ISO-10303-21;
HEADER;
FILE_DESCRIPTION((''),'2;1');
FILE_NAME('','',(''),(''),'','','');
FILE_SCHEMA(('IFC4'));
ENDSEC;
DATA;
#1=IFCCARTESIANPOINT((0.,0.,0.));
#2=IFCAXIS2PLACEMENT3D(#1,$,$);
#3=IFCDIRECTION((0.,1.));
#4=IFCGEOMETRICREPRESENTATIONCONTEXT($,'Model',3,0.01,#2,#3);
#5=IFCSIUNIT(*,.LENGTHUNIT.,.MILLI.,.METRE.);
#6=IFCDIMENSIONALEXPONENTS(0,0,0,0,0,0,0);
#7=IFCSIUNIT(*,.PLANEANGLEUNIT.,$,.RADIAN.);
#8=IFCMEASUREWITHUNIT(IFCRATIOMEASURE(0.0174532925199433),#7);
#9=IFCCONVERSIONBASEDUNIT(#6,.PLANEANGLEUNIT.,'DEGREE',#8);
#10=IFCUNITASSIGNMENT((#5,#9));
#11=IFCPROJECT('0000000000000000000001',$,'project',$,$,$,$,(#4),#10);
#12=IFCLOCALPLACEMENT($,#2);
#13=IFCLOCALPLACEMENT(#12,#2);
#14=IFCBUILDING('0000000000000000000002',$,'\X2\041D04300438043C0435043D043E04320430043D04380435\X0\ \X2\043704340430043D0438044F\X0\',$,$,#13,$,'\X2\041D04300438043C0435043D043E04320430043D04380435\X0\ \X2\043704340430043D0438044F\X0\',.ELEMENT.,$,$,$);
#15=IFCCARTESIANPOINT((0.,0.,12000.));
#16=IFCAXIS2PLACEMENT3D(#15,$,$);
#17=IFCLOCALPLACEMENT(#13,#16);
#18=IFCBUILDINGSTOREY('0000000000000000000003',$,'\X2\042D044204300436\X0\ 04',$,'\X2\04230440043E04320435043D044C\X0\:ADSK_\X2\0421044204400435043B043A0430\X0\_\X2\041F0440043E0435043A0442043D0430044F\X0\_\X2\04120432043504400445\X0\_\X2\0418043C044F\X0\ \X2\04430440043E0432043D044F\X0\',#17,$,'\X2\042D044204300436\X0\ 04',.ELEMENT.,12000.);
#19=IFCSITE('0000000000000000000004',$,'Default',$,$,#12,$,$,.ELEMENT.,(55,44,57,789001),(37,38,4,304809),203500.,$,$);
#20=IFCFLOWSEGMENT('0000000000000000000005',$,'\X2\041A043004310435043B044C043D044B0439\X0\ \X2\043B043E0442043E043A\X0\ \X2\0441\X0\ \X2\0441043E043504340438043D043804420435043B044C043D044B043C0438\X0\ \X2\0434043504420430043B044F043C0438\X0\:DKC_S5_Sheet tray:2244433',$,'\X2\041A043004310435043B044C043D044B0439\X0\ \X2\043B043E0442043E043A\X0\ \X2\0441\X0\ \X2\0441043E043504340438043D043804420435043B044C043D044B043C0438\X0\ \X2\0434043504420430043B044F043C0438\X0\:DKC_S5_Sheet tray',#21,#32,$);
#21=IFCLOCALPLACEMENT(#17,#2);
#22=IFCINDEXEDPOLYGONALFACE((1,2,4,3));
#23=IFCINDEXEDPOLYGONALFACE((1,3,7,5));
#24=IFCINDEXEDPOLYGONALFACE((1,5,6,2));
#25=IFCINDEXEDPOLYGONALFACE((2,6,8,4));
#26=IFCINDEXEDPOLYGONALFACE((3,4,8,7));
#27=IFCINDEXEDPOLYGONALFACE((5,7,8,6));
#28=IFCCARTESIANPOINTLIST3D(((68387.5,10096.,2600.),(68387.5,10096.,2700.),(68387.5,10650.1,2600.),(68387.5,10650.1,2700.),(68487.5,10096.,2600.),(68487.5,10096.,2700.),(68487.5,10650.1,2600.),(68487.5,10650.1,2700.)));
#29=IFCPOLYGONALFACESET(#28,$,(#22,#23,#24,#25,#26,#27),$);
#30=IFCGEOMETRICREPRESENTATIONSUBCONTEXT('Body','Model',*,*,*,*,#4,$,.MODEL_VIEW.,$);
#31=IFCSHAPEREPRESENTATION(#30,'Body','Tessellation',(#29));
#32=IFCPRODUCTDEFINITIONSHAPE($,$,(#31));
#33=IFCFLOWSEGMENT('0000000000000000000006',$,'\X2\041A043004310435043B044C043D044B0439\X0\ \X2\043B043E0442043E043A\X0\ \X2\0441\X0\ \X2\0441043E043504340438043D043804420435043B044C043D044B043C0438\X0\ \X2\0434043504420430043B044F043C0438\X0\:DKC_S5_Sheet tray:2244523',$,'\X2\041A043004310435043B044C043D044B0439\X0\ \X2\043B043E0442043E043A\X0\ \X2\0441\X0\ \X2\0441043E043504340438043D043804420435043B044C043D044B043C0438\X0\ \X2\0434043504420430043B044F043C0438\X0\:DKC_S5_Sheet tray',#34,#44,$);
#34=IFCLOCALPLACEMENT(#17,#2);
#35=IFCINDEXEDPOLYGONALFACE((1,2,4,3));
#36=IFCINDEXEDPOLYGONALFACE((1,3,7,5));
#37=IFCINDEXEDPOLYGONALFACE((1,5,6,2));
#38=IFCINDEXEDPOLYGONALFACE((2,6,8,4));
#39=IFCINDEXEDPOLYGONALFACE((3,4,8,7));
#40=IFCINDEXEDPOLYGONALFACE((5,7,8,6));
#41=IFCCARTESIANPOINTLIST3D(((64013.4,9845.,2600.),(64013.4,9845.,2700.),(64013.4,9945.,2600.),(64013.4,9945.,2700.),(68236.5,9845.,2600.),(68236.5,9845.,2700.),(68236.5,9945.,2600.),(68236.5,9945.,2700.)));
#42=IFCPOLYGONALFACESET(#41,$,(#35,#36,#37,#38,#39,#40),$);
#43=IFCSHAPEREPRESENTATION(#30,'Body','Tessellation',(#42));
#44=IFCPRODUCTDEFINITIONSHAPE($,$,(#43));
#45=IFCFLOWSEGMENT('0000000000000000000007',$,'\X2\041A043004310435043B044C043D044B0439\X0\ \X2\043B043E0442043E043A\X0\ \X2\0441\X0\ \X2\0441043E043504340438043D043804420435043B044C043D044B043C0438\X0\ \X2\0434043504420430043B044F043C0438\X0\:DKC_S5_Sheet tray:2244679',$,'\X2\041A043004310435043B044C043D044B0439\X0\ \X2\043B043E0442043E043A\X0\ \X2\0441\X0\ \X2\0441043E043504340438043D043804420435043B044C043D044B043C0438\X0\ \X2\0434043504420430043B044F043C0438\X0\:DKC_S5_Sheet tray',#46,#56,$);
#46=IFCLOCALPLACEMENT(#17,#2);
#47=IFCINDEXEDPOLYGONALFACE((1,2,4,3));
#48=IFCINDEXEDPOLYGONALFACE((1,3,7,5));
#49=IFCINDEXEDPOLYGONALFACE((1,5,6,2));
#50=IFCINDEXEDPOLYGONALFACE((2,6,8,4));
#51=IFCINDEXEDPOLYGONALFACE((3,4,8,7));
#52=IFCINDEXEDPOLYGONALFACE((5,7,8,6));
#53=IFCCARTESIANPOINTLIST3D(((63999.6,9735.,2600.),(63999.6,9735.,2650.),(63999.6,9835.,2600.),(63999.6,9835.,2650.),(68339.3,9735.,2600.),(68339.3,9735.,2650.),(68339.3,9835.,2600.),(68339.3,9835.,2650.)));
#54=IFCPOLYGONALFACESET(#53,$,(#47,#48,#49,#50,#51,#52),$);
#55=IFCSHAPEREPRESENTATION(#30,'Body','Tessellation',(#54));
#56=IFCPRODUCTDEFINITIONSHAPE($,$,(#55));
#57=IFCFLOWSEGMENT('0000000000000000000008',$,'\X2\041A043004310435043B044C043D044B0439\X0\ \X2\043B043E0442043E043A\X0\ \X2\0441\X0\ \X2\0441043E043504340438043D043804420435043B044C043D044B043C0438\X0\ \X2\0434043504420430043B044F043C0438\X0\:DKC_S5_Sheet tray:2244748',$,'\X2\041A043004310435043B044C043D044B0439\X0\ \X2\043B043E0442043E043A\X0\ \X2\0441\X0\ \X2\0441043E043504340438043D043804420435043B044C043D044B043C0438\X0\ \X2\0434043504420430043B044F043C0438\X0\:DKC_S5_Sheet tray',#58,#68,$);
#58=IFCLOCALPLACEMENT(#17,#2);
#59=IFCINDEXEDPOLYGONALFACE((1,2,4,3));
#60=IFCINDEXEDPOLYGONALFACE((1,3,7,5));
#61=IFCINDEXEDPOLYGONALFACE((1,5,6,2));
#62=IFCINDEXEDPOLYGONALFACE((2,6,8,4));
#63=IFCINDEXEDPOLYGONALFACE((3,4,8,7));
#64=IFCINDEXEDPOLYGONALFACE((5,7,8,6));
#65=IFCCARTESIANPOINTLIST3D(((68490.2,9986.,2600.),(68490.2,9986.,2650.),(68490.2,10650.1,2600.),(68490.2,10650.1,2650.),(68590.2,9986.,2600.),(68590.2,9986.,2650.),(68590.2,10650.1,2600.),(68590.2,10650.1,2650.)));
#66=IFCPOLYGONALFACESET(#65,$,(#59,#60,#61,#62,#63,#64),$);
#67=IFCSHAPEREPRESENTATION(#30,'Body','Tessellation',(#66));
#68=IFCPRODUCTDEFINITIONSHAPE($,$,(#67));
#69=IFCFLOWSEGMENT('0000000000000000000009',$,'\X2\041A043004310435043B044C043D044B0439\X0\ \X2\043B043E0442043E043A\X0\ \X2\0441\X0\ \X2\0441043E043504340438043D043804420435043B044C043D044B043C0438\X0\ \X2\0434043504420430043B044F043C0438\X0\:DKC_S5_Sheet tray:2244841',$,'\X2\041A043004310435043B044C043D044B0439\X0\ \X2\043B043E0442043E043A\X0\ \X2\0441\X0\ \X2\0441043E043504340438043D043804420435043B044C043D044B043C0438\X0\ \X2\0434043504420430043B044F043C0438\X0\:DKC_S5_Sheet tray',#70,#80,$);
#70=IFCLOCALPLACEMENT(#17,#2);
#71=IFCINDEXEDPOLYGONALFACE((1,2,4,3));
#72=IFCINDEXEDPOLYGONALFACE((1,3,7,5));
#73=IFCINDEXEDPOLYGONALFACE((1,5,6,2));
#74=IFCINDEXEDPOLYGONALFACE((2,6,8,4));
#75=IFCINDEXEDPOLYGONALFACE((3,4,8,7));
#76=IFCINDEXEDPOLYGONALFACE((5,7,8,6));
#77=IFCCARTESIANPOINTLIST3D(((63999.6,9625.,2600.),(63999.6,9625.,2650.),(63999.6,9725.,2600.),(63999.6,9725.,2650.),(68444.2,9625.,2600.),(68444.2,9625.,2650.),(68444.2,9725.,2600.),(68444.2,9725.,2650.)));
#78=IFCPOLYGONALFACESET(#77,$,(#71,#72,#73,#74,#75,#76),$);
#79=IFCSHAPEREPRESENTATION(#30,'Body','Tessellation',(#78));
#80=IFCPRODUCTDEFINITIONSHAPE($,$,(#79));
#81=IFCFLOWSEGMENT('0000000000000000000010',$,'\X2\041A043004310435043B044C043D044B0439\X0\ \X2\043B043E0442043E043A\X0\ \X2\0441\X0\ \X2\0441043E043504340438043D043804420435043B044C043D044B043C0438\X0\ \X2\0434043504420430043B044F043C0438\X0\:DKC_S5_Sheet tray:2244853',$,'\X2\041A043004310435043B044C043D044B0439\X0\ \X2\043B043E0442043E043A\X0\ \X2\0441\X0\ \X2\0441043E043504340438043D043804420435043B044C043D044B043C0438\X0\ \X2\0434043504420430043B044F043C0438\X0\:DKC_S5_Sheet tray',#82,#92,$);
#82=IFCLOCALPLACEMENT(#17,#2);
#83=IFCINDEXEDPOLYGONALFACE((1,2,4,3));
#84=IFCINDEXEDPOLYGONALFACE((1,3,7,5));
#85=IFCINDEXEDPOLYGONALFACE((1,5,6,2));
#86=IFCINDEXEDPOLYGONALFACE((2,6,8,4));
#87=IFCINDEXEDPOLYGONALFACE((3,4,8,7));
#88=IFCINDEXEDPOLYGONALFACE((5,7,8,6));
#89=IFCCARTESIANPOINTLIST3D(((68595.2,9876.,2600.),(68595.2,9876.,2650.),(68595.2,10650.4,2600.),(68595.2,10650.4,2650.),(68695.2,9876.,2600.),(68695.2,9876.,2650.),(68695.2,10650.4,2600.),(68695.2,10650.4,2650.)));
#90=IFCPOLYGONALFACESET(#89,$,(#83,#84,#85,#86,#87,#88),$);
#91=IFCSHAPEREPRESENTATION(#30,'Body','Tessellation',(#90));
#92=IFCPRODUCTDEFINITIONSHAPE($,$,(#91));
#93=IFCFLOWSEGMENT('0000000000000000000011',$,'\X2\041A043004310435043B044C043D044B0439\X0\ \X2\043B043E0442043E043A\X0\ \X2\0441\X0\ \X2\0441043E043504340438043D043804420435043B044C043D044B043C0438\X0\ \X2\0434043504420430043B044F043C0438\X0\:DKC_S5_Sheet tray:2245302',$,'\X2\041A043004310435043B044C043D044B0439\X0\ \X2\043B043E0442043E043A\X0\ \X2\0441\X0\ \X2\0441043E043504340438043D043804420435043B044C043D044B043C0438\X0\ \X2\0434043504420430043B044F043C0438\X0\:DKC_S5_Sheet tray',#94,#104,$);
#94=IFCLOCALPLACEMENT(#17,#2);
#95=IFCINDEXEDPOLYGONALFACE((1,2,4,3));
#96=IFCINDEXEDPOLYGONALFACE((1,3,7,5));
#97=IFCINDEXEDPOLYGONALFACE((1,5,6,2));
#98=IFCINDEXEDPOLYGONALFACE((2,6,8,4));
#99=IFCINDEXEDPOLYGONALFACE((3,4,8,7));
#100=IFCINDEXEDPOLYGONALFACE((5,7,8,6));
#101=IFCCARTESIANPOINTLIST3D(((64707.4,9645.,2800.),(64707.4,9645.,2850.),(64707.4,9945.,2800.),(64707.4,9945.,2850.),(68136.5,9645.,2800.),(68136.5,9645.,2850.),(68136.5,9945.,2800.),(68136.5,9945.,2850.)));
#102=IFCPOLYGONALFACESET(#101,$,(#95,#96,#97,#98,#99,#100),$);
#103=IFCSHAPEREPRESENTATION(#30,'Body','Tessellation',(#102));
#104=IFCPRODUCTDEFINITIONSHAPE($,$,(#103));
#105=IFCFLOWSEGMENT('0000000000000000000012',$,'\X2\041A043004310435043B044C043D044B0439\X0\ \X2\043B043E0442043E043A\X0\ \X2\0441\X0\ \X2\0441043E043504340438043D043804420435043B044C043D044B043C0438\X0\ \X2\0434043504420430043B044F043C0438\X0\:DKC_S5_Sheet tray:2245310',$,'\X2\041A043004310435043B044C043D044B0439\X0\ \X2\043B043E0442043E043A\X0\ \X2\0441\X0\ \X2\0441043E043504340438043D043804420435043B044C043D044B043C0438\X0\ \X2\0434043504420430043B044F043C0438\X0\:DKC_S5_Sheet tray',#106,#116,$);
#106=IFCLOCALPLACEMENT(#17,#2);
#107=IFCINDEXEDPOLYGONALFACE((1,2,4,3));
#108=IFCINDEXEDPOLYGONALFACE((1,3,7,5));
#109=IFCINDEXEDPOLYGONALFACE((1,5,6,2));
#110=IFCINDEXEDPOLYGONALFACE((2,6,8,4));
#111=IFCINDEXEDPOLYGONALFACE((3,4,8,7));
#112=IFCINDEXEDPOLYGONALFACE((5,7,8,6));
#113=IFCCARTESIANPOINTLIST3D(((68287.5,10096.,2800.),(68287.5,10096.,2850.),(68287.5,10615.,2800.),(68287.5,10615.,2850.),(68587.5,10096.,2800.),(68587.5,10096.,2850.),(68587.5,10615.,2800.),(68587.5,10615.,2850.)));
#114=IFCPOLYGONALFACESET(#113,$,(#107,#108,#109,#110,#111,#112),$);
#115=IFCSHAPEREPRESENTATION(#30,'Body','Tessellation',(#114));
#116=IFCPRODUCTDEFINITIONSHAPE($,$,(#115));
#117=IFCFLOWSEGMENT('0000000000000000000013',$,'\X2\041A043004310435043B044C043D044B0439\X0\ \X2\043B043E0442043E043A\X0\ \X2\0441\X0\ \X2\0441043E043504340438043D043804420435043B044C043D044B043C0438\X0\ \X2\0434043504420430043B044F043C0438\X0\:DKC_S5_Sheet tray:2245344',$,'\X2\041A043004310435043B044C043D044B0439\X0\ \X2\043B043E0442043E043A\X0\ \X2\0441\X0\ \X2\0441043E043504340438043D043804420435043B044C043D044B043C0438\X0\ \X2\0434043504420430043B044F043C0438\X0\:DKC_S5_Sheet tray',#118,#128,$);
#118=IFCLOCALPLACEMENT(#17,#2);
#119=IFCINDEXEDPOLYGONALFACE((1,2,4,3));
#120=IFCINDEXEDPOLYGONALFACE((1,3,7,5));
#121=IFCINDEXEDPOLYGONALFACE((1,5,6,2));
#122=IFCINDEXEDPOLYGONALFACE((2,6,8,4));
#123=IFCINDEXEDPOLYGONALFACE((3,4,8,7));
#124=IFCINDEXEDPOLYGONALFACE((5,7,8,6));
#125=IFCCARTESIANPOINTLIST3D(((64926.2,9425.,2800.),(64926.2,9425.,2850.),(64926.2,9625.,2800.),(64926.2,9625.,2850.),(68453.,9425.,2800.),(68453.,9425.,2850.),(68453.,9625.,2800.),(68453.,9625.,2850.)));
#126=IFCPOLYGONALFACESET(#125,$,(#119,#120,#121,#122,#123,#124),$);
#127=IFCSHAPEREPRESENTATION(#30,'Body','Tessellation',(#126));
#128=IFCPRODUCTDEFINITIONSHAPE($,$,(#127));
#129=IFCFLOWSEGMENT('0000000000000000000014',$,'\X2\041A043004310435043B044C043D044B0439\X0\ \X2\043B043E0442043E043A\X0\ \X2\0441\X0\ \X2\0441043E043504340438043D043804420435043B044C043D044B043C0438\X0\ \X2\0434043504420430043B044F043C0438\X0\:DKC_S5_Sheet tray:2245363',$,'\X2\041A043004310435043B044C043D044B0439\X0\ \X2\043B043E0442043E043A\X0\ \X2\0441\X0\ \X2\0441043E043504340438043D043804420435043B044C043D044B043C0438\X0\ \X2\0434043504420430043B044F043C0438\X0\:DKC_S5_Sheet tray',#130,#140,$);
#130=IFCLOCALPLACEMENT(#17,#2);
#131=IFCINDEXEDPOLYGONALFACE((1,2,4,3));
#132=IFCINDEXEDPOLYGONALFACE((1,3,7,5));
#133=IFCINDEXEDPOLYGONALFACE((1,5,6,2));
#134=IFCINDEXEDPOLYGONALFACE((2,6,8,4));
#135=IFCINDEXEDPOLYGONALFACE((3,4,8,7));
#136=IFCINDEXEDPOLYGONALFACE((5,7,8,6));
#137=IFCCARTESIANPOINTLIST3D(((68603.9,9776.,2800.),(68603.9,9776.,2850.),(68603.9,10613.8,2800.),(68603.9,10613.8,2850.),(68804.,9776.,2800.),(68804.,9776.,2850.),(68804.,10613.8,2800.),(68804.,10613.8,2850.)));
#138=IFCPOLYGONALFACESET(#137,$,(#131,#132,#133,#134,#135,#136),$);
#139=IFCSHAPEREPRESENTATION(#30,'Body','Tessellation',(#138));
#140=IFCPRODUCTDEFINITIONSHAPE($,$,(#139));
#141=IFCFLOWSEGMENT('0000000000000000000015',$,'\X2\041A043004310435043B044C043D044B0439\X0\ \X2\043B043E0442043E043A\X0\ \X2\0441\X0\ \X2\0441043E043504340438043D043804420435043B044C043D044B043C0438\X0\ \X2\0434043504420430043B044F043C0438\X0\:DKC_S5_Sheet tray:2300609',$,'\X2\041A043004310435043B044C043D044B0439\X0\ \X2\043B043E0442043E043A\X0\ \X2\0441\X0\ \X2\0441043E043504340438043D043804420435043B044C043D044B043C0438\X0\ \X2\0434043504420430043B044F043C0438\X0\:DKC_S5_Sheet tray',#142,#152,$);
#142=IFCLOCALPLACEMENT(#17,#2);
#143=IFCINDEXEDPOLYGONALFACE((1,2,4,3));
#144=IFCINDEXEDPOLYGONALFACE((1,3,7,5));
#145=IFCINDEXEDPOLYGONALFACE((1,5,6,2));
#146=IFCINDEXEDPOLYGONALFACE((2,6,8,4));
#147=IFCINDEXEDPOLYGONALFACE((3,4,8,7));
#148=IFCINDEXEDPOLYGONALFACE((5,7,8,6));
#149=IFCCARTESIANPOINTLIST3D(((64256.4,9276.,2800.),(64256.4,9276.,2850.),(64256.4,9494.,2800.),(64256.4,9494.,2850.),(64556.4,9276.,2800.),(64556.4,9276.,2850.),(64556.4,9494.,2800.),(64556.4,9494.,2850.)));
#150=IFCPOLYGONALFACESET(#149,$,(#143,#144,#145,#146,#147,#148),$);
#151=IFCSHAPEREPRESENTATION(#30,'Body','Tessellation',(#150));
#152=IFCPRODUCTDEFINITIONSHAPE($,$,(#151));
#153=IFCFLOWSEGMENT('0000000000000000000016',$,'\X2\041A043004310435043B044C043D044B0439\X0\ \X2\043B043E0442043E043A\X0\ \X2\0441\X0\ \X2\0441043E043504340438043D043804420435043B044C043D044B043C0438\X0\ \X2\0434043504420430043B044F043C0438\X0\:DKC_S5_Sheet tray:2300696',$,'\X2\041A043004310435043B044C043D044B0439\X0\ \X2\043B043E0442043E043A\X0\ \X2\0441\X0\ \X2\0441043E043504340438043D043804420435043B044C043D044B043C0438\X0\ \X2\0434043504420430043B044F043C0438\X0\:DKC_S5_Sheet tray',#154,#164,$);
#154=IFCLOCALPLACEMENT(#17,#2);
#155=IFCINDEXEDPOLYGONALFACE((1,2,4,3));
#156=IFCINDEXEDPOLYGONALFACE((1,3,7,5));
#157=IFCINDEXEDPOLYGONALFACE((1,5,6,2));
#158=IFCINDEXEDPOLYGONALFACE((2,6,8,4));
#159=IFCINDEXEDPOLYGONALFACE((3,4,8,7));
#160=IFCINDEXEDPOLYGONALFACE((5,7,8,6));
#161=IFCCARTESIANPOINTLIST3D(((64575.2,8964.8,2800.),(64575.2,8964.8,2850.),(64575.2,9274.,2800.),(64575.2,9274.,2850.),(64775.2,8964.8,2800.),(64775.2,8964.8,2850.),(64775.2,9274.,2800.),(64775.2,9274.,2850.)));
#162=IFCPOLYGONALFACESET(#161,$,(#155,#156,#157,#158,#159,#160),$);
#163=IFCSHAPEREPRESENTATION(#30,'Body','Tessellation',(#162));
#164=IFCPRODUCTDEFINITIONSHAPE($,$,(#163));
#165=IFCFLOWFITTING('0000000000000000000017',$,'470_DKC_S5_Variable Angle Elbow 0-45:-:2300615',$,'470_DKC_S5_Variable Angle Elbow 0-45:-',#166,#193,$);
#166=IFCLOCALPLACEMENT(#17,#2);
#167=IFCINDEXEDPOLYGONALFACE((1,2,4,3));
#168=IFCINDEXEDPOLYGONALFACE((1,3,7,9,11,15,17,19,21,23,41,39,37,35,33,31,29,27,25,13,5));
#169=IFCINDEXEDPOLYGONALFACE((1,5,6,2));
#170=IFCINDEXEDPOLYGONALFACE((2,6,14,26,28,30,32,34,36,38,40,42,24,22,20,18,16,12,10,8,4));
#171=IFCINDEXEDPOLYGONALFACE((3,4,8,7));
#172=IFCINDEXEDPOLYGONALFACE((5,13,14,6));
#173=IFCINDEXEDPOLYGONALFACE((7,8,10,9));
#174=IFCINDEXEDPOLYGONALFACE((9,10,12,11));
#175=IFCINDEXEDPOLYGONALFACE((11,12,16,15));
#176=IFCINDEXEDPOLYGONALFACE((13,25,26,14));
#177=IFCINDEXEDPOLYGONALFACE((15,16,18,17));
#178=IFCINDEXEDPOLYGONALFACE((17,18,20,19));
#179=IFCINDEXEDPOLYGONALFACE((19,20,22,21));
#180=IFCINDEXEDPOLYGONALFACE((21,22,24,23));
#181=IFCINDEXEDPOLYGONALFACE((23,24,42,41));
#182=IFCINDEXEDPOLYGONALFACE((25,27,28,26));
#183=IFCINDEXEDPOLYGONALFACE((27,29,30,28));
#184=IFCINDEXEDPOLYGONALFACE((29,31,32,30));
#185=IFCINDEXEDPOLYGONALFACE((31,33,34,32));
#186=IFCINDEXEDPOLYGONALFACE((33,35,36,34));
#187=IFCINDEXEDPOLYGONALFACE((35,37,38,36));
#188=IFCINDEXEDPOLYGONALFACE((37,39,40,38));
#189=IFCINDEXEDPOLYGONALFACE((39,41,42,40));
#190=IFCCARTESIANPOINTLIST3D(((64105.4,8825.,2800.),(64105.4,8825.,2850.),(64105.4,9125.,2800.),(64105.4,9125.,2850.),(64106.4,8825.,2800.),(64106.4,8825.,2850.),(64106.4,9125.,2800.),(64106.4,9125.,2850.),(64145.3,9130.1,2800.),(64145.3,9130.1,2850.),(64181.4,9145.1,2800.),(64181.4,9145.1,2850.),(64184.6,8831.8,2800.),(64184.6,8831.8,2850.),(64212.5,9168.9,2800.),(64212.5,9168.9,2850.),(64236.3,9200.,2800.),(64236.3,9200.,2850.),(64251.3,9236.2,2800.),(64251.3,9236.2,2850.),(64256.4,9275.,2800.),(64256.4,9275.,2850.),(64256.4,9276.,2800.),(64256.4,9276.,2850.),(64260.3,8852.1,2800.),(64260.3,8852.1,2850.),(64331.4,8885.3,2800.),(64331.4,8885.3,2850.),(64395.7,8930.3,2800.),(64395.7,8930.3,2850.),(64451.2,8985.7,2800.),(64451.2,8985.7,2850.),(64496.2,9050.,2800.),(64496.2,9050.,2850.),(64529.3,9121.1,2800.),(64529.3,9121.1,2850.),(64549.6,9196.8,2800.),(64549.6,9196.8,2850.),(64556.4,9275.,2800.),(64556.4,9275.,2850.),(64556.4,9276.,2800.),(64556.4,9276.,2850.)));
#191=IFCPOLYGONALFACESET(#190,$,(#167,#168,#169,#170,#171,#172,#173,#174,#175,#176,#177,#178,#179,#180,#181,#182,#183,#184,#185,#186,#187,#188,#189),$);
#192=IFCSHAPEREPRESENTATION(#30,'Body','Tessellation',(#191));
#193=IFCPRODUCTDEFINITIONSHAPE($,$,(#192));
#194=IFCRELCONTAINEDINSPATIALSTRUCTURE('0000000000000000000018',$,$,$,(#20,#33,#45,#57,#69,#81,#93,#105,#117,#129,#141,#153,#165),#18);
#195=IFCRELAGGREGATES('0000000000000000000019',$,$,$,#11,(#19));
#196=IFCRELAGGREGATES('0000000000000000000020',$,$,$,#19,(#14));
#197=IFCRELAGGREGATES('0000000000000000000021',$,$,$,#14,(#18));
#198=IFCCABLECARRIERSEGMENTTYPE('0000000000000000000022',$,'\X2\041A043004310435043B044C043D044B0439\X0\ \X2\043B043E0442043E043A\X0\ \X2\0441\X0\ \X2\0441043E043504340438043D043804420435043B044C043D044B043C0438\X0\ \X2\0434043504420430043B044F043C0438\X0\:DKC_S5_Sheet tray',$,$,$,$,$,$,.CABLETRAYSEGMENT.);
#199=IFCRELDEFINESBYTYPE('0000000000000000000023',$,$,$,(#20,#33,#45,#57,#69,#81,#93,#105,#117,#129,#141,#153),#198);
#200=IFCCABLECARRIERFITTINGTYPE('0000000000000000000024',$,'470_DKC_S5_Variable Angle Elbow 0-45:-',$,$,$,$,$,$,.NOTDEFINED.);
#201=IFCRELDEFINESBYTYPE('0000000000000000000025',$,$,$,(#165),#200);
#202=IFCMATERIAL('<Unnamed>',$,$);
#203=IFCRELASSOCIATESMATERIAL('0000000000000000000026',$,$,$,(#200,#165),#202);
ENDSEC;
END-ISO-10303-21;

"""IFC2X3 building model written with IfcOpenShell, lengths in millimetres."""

from ifc_helpers import new_model, entity, si_unit, converted_unit, direction, frame, frame_2d, origin, origin_2d_with_axis, place, context, subcontext, project, spatial, polyline, circle_curve, parameter, trimmed, segment, composite_curve, rectangle, outline, extrude, source, transform, mapped, material, type_object, type_shapes, element, save


model = new_model("IFC2X3")

# Units and contexts
model_context = context("Model", 3, precision=0.01, world=origin(), true_north=direction((0.0, 1.0)))
body_context = subcontext(model_context, "Body", "Model", "MODEL_VIEW")
ifc_project = project(units=[si_unit("LENGTHUNIT", "METRE", prefix="MILLI"), converted_unit("PLANEANGLEUNIT", "DEGREE", entity("IfcRatioMeasure", 0.0174532925199433), si_unit("PLANEANGLEUNIT", "RADIAN"), dimensions=[0, 0, 0, 0, 0, 0, 0])], contexts=[model_context])

# Site, building, storey
site_placement = place(None, origin())
site = spatial("IfcSite", under=ifc_project, at=site_placement, Name="Default", CompositionType="ELEMENT", RefLatitude=(55, 44, 57, 789001), RefLongitude=(37, 38, 4, 304809), RefElevation=203500.0)
building_placement = place(site_placement, origin())
building = spatial("IfcBuilding", under=site, at=building_placement, Name="Наименование здания", LongName="Наименование здания", CompositionType="ELEMENT")
storey_placement = place(building_placement, frame((0.0, 0.0, 12000.0)))
storey = spatial("IfcBuildingStorey", under=building, at=storey_placement, Name="Этаж 04", ObjectType="Уровень:ADSK_Стрелка_Проектная_Вверх_Имя уровня", LongName="Этаж 04", CompositionType="ELEMENT", Elevation=12000.0)

# Flow segments
cable_carrier_segment_type = type_object("IfcCableCarrierSegmentType", Name="Кабельный лоток с соединительными деталями:DKC_S5_Sheet tray", PredefinedType="CABLETRAYSEGMENT")
flow_segment_1_placement = place(storey_placement, frame((68387.5, 10096.0, 2600.0)))
element("IfcFlowSegment", 1, at=flow_segment_1_placement, inside=storey, type_object=cable_carrier_segment_type, Name="Кабельный лоток с соединительными деталями:DKC_S5_Sheet tray:2244433", ObjectType="Кабельный лоток с соединительными деталями:DKC_S5_Sheet tray", context=body_context, shape_type="SweptSolid", body=[
    extrude(rectangle(XDim=554.1, YDim=100.0, at=origin_2d_with_axis()), frame((50.0, 277.1, 0.0), z_axis=(0.0, 0.0, 1.0), x_axis=(0.0, -1.0, 0.0)), (0.0, 0.0, 1.0), 100.0),
])
flow_segment_2_placement = place(storey_placement, frame((64013.4, 9845.0, 2600.0)))
element("IfcFlowSegment", 2, at=flow_segment_2_placement, inside=storey, type_object=cable_carrier_segment_type, Name="Кабельный лоток с соединительными деталями:DKC_S5_Sheet tray:2244523", ObjectType="Кабельный лоток с соединительными деталями:DKC_S5_Sheet tray", context=body_context, shape_type="SweptSolid", body=[
    extrude(rectangle(XDim=4223.1, YDim=100.0, at=origin_2d_with_axis()), frame((2111.5, 50.0, 0.0), z_axis=(0.0, 0.0, 1.0), x_axis=(-1.0, 0.0, 0.0)), (0.0, 0.0, 1.0), 100.0),
])
flow_segment_3_placement = place(storey_placement, frame((63999.6, 9735.0, 2600.0)))
element("IfcFlowSegment", 3, at=flow_segment_3_placement, inside=storey, type_object=cable_carrier_segment_type, Name="Кабельный лоток с соединительными деталями:DKC_S5_Sheet tray:2244679", ObjectType="Кабельный лоток с соединительными деталями:DKC_S5_Sheet tray", context=body_context, shape_type="SweptSolid", body=[
    extrude(rectangle(XDim=4339.7, YDim=100.0, at=origin_2d_with_axis()), frame((2169.8, 50.0, 0.0)), (0.0, 0.0, 1.0), 50.0),
])
flow_segment_4_placement = place(storey_placement, frame((68490.2, 9986.0, 2600.0)))
element("IfcFlowSegment", 4, at=flow_segment_4_placement, inside=storey, type_object=cable_carrier_segment_type, Name="Кабельный лоток с соединительными деталями:DKC_S5_Sheet tray:2244748", ObjectType="Кабельный лоток с соединительными деталями:DKC_S5_Sheet tray", context=body_context, shape_type="SweptSolid", body=[
    extrude(rectangle(XDim=664.1, YDim=100.0, at=origin_2d_with_axis()), frame((50.0, 332.1, 0.0), z_axis=(0.0, 0.0, 1.0), x_axis=(0.0, 1.0, 0.0)), (0.0, 0.0, 1.0), 50.0),
])
flow_segment_5_placement = place(storey_placement, frame((63999.6, 9625.0, 2600.0)))
element("IfcFlowSegment", 5, at=flow_segment_5_placement, inside=storey, type_object=cable_carrier_segment_type, Name="Кабельный лоток с соединительными деталями:DKC_S5_Sheet tray:2244841", ObjectType="Кабельный лоток с соединительными деталями:DKC_S5_Sheet tray", context=body_context, shape_type="SweptSolid", body=[
    extrude(rectangle(XDim=4444.6, YDim=100.0, at=origin_2d_with_axis()), frame((2222.3, 50.0, 0.0)), (0.0, 0.0, 1.0), 50.0),
])
flow_segment_6_placement = place(storey_placement, frame((68595.2, 9876.0, 2600.0)))
element("IfcFlowSegment", 6, at=flow_segment_6_placement, inside=storey, type_object=cable_carrier_segment_type, Name="Кабельный лоток с соединительными деталями:DKC_S5_Sheet tray:2244853", ObjectType="Кабельный лоток с соединительными деталями:DKC_S5_Sheet tray", context=body_context, shape_type="SweptSolid", body=[
    extrude(rectangle(XDim=774.4, YDim=100.0, at=origin_2d_with_axis()), frame((50.0, 387.2, 0.0), z_axis=(0.0, 0.0, 1.0), x_axis=(0.0, 1.0, 0.0)), (0.0, 0.0, 1.0), 50.0),
])
flow_segment_7_placement = place(storey_placement, frame((64707.4, 9645.0, 2800.0)))
element("IfcFlowSegment", 7, at=flow_segment_7_placement, inside=storey, type_object=cable_carrier_segment_type, Name="Кабельный лоток с соединительными деталями:DKC_S5_Sheet tray:2245302", ObjectType="Кабельный лоток с соединительными деталями:DKC_S5_Sheet tray", context=body_context, shape_type="SweptSolid", body=[
    extrude(rectangle(XDim=3429.1, YDim=300.0, at=origin_2d_with_axis()), frame((1714.5, 150.0, 0.0), z_axis=(0.0, 0.0, 1.0), x_axis=(-1.0, 0.0, 0.0)), (0.0, 0.0, 1.0), 50.0),
])
flow_segment_8_placement = place(storey_placement, frame((68287.5, 10096.0, 2800.0)))
element("IfcFlowSegment", 8, at=flow_segment_8_placement, inside=storey, type_object=cable_carrier_segment_type, Name="Кабельный лоток с соединительными деталями:DKC_S5_Sheet tray:2245310", ObjectType="Кабельный лоток с соединительными деталями:DKC_S5_Sheet tray", context=body_context, shape_type="SweptSolid", body=[
    extrude(rectangle(XDim=519.0, YDim=300.0, at=origin_2d_with_axis()), frame((150.0, 259.5, 0.0), z_axis=(0.0, 0.0, 1.0), x_axis=(0.0, 1.0, 0.0)), (0.0, 0.0, 1.0), 50.0),
])
flow_segment_9_placement = place(storey_placement, frame((64926.2, 9425.0, 2800.0)))
element("IfcFlowSegment", 9, at=flow_segment_9_placement, inside=storey, type_object=cable_carrier_segment_type, Name="Кабельный лоток с соединительными деталями:DKC_S5_Sheet tray:2245344", ObjectType="Кабельный лоток с соединительными деталями:DKC_S5_Sheet tray", context=body_context, shape_type="SweptSolid", body=[
    extrude(rectangle(XDim=3526.7, YDim=200.0, at=origin_2d_with_axis()), frame((1763.4, 100.0, 0.0), z_axis=(0.0, 0.0, 1.0), x_axis=(-1.0, 0.0, 0.0)), (0.0, 0.0, 1.0), 50.0),
])
flow_segment_10_placement = place(storey_placement, frame((68603.9, 9776.0, 2800.0)))
element("IfcFlowSegment", 10, at=flow_segment_10_placement, inside=storey, type_object=cable_carrier_segment_type, Name="Кабельный лоток с соединительными деталями:DKC_S5_Sheet tray:2245363", ObjectType="Кабельный лоток с соединительными деталями:DKC_S5_Sheet tray", context=body_context, shape_type="SweptSolid", body=[
    extrude(rectangle(XDim=837.8, YDim=200.0, at=origin_2d_with_axis()), frame((100.0, 418.9, 0.0), z_axis=(0.0, 0.0, 1.0), x_axis=(0.0, 1.0, 0.0)), (0.0, 0.0, 1.0), 50.0),
])
flow_segment_11_placement = place(storey_placement, frame((64256.4, 9276.0, 2800.0)))
element("IfcFlowSegment", 11, at=flow_segment_11_placement, inside=storey, type_object=cable_carrier_segment_type, Name="Кабельный лоток с соединительными деталями:DKC_S5_Sheet tray:2300609", ObjectType="Кабельный лоток с соединительными деталями:DKC_S5_Sheet tray", context=body_context, shape_type="SweptSolid", body=[
    extrude(rectangle(XDim=218.0, YDim=300.0, at=origin_2d_with_axis()), frame((150.0, 109.0, 0.0), z_axis=(0.0, 0.0, 1.0), x_axis=(0.0, 1.0, 0.0)), (0.0, 0.0, 1.0), 50.0),
])
flow_segment_12_placement = place(storey_placement, frame((64575.2, 8964.8, 2800.0)))
element("IfcFlowSegment", 12, at=flow_segment_12_placement, inside=storey, type_object=cable_carrier_segment_type, Name="Кабельный лоток с соединительными деталями:DKC_S5_Sheet tray:2300696", ObjectType="Кабельный лоток с соединительными деталями:DKC_S5_Sheet tray", context=body_context, shape_type="SweptSolid", body=[
    extrude(rectangle(XDim=309.2, YDim=200.0, at=origin_2d_with_axis()), frame((100.0, 154.6, 0.0), z_axis=(0.0, 0.0, 1.0), x_axis=(0.0, -1.0, 0.0)), (0.0, 0.0, 1.0), 50.0),
])

# Flow fitting
ifc_material = material(Name="<Unnamed>")
cable_carrier_fitting_type_1 = type_object("IfcCableCarrierFittingType", Name="470_DKC_S5_Variable Angle Elbow 0-45:-", PredefinedType="NOTDEFINED", material=ifc_material)
shared_shape_1 = source(origin(), body_context, "Body", "SweptSolid", [
    extrude(outline(composite_curve([segment(polyline([(-150.8, -300.2), (-149.8, -300.2)]), True, "CONTINUOUS"), segment(trimmed(circle_curve(frame_2d((-149.8, 149.8), x_axis=(0.0, -1.0)), 450.0), [parameter(0.0)], [parameter(90.0)], True, "PARAMETER"), True, "CONTINUOUS"), segment(polyline([(300.2, 149.8), (300.2, 150.8)]), True, "CONTINUOUS"), segment(polyline([(300.2, 150.8), (0.2, 150.8)]), True, "CONTINUOUS"), segment(polyline([(0.2, 150.8), (0.2, 149.8)]), True, "CONTINUOUS"), segment(trimmed(circle_curve(frame_2d((-149.8, 149.8), x_axis=(0.0, -1.0)), 150.0), [parameter(0.0)], [parameter(90.0)], True, "PARAMETER"), False, "CONTINUOUS"), segment(polyline([(-149.8, -0.2), (-150.8, -0.2)]), True, "CONTINUOUS"), segment(polyline([(-150.8, -0.2), (-150.8, -300.2)]), True, "CONTINUOUS")], self_intersect=False)), frame((-150.2, 150.2, -25.0)), (0.0, 0.0, 1.0), 50.0),
])
type_shapes(cable_carrier_fitting_type_1, [shared_shape_1])
for number, where, name in (
    (13, (64406.4, 8975.0, 2825.0), "470_DKC_S5_Variable Angle Elbow 0-45:-:2300615"),
):
    element("IfcFlowFitting", number, at=place(storey_placement, frame(where)), inside=storey, type_object=cable_carrier_fitting_type_1, material=ifc_material, Name=name, ObjectType="470_DKC_S5_Variable Angle Elbow 0-45:-", context=body_context, shape_type="MappedRepresentation", body=[
        mapped(shared_shape_1, transform((0.0, 0.0, 0.0), scale=1.0)),
    ])

save(model, "model.ifc")
